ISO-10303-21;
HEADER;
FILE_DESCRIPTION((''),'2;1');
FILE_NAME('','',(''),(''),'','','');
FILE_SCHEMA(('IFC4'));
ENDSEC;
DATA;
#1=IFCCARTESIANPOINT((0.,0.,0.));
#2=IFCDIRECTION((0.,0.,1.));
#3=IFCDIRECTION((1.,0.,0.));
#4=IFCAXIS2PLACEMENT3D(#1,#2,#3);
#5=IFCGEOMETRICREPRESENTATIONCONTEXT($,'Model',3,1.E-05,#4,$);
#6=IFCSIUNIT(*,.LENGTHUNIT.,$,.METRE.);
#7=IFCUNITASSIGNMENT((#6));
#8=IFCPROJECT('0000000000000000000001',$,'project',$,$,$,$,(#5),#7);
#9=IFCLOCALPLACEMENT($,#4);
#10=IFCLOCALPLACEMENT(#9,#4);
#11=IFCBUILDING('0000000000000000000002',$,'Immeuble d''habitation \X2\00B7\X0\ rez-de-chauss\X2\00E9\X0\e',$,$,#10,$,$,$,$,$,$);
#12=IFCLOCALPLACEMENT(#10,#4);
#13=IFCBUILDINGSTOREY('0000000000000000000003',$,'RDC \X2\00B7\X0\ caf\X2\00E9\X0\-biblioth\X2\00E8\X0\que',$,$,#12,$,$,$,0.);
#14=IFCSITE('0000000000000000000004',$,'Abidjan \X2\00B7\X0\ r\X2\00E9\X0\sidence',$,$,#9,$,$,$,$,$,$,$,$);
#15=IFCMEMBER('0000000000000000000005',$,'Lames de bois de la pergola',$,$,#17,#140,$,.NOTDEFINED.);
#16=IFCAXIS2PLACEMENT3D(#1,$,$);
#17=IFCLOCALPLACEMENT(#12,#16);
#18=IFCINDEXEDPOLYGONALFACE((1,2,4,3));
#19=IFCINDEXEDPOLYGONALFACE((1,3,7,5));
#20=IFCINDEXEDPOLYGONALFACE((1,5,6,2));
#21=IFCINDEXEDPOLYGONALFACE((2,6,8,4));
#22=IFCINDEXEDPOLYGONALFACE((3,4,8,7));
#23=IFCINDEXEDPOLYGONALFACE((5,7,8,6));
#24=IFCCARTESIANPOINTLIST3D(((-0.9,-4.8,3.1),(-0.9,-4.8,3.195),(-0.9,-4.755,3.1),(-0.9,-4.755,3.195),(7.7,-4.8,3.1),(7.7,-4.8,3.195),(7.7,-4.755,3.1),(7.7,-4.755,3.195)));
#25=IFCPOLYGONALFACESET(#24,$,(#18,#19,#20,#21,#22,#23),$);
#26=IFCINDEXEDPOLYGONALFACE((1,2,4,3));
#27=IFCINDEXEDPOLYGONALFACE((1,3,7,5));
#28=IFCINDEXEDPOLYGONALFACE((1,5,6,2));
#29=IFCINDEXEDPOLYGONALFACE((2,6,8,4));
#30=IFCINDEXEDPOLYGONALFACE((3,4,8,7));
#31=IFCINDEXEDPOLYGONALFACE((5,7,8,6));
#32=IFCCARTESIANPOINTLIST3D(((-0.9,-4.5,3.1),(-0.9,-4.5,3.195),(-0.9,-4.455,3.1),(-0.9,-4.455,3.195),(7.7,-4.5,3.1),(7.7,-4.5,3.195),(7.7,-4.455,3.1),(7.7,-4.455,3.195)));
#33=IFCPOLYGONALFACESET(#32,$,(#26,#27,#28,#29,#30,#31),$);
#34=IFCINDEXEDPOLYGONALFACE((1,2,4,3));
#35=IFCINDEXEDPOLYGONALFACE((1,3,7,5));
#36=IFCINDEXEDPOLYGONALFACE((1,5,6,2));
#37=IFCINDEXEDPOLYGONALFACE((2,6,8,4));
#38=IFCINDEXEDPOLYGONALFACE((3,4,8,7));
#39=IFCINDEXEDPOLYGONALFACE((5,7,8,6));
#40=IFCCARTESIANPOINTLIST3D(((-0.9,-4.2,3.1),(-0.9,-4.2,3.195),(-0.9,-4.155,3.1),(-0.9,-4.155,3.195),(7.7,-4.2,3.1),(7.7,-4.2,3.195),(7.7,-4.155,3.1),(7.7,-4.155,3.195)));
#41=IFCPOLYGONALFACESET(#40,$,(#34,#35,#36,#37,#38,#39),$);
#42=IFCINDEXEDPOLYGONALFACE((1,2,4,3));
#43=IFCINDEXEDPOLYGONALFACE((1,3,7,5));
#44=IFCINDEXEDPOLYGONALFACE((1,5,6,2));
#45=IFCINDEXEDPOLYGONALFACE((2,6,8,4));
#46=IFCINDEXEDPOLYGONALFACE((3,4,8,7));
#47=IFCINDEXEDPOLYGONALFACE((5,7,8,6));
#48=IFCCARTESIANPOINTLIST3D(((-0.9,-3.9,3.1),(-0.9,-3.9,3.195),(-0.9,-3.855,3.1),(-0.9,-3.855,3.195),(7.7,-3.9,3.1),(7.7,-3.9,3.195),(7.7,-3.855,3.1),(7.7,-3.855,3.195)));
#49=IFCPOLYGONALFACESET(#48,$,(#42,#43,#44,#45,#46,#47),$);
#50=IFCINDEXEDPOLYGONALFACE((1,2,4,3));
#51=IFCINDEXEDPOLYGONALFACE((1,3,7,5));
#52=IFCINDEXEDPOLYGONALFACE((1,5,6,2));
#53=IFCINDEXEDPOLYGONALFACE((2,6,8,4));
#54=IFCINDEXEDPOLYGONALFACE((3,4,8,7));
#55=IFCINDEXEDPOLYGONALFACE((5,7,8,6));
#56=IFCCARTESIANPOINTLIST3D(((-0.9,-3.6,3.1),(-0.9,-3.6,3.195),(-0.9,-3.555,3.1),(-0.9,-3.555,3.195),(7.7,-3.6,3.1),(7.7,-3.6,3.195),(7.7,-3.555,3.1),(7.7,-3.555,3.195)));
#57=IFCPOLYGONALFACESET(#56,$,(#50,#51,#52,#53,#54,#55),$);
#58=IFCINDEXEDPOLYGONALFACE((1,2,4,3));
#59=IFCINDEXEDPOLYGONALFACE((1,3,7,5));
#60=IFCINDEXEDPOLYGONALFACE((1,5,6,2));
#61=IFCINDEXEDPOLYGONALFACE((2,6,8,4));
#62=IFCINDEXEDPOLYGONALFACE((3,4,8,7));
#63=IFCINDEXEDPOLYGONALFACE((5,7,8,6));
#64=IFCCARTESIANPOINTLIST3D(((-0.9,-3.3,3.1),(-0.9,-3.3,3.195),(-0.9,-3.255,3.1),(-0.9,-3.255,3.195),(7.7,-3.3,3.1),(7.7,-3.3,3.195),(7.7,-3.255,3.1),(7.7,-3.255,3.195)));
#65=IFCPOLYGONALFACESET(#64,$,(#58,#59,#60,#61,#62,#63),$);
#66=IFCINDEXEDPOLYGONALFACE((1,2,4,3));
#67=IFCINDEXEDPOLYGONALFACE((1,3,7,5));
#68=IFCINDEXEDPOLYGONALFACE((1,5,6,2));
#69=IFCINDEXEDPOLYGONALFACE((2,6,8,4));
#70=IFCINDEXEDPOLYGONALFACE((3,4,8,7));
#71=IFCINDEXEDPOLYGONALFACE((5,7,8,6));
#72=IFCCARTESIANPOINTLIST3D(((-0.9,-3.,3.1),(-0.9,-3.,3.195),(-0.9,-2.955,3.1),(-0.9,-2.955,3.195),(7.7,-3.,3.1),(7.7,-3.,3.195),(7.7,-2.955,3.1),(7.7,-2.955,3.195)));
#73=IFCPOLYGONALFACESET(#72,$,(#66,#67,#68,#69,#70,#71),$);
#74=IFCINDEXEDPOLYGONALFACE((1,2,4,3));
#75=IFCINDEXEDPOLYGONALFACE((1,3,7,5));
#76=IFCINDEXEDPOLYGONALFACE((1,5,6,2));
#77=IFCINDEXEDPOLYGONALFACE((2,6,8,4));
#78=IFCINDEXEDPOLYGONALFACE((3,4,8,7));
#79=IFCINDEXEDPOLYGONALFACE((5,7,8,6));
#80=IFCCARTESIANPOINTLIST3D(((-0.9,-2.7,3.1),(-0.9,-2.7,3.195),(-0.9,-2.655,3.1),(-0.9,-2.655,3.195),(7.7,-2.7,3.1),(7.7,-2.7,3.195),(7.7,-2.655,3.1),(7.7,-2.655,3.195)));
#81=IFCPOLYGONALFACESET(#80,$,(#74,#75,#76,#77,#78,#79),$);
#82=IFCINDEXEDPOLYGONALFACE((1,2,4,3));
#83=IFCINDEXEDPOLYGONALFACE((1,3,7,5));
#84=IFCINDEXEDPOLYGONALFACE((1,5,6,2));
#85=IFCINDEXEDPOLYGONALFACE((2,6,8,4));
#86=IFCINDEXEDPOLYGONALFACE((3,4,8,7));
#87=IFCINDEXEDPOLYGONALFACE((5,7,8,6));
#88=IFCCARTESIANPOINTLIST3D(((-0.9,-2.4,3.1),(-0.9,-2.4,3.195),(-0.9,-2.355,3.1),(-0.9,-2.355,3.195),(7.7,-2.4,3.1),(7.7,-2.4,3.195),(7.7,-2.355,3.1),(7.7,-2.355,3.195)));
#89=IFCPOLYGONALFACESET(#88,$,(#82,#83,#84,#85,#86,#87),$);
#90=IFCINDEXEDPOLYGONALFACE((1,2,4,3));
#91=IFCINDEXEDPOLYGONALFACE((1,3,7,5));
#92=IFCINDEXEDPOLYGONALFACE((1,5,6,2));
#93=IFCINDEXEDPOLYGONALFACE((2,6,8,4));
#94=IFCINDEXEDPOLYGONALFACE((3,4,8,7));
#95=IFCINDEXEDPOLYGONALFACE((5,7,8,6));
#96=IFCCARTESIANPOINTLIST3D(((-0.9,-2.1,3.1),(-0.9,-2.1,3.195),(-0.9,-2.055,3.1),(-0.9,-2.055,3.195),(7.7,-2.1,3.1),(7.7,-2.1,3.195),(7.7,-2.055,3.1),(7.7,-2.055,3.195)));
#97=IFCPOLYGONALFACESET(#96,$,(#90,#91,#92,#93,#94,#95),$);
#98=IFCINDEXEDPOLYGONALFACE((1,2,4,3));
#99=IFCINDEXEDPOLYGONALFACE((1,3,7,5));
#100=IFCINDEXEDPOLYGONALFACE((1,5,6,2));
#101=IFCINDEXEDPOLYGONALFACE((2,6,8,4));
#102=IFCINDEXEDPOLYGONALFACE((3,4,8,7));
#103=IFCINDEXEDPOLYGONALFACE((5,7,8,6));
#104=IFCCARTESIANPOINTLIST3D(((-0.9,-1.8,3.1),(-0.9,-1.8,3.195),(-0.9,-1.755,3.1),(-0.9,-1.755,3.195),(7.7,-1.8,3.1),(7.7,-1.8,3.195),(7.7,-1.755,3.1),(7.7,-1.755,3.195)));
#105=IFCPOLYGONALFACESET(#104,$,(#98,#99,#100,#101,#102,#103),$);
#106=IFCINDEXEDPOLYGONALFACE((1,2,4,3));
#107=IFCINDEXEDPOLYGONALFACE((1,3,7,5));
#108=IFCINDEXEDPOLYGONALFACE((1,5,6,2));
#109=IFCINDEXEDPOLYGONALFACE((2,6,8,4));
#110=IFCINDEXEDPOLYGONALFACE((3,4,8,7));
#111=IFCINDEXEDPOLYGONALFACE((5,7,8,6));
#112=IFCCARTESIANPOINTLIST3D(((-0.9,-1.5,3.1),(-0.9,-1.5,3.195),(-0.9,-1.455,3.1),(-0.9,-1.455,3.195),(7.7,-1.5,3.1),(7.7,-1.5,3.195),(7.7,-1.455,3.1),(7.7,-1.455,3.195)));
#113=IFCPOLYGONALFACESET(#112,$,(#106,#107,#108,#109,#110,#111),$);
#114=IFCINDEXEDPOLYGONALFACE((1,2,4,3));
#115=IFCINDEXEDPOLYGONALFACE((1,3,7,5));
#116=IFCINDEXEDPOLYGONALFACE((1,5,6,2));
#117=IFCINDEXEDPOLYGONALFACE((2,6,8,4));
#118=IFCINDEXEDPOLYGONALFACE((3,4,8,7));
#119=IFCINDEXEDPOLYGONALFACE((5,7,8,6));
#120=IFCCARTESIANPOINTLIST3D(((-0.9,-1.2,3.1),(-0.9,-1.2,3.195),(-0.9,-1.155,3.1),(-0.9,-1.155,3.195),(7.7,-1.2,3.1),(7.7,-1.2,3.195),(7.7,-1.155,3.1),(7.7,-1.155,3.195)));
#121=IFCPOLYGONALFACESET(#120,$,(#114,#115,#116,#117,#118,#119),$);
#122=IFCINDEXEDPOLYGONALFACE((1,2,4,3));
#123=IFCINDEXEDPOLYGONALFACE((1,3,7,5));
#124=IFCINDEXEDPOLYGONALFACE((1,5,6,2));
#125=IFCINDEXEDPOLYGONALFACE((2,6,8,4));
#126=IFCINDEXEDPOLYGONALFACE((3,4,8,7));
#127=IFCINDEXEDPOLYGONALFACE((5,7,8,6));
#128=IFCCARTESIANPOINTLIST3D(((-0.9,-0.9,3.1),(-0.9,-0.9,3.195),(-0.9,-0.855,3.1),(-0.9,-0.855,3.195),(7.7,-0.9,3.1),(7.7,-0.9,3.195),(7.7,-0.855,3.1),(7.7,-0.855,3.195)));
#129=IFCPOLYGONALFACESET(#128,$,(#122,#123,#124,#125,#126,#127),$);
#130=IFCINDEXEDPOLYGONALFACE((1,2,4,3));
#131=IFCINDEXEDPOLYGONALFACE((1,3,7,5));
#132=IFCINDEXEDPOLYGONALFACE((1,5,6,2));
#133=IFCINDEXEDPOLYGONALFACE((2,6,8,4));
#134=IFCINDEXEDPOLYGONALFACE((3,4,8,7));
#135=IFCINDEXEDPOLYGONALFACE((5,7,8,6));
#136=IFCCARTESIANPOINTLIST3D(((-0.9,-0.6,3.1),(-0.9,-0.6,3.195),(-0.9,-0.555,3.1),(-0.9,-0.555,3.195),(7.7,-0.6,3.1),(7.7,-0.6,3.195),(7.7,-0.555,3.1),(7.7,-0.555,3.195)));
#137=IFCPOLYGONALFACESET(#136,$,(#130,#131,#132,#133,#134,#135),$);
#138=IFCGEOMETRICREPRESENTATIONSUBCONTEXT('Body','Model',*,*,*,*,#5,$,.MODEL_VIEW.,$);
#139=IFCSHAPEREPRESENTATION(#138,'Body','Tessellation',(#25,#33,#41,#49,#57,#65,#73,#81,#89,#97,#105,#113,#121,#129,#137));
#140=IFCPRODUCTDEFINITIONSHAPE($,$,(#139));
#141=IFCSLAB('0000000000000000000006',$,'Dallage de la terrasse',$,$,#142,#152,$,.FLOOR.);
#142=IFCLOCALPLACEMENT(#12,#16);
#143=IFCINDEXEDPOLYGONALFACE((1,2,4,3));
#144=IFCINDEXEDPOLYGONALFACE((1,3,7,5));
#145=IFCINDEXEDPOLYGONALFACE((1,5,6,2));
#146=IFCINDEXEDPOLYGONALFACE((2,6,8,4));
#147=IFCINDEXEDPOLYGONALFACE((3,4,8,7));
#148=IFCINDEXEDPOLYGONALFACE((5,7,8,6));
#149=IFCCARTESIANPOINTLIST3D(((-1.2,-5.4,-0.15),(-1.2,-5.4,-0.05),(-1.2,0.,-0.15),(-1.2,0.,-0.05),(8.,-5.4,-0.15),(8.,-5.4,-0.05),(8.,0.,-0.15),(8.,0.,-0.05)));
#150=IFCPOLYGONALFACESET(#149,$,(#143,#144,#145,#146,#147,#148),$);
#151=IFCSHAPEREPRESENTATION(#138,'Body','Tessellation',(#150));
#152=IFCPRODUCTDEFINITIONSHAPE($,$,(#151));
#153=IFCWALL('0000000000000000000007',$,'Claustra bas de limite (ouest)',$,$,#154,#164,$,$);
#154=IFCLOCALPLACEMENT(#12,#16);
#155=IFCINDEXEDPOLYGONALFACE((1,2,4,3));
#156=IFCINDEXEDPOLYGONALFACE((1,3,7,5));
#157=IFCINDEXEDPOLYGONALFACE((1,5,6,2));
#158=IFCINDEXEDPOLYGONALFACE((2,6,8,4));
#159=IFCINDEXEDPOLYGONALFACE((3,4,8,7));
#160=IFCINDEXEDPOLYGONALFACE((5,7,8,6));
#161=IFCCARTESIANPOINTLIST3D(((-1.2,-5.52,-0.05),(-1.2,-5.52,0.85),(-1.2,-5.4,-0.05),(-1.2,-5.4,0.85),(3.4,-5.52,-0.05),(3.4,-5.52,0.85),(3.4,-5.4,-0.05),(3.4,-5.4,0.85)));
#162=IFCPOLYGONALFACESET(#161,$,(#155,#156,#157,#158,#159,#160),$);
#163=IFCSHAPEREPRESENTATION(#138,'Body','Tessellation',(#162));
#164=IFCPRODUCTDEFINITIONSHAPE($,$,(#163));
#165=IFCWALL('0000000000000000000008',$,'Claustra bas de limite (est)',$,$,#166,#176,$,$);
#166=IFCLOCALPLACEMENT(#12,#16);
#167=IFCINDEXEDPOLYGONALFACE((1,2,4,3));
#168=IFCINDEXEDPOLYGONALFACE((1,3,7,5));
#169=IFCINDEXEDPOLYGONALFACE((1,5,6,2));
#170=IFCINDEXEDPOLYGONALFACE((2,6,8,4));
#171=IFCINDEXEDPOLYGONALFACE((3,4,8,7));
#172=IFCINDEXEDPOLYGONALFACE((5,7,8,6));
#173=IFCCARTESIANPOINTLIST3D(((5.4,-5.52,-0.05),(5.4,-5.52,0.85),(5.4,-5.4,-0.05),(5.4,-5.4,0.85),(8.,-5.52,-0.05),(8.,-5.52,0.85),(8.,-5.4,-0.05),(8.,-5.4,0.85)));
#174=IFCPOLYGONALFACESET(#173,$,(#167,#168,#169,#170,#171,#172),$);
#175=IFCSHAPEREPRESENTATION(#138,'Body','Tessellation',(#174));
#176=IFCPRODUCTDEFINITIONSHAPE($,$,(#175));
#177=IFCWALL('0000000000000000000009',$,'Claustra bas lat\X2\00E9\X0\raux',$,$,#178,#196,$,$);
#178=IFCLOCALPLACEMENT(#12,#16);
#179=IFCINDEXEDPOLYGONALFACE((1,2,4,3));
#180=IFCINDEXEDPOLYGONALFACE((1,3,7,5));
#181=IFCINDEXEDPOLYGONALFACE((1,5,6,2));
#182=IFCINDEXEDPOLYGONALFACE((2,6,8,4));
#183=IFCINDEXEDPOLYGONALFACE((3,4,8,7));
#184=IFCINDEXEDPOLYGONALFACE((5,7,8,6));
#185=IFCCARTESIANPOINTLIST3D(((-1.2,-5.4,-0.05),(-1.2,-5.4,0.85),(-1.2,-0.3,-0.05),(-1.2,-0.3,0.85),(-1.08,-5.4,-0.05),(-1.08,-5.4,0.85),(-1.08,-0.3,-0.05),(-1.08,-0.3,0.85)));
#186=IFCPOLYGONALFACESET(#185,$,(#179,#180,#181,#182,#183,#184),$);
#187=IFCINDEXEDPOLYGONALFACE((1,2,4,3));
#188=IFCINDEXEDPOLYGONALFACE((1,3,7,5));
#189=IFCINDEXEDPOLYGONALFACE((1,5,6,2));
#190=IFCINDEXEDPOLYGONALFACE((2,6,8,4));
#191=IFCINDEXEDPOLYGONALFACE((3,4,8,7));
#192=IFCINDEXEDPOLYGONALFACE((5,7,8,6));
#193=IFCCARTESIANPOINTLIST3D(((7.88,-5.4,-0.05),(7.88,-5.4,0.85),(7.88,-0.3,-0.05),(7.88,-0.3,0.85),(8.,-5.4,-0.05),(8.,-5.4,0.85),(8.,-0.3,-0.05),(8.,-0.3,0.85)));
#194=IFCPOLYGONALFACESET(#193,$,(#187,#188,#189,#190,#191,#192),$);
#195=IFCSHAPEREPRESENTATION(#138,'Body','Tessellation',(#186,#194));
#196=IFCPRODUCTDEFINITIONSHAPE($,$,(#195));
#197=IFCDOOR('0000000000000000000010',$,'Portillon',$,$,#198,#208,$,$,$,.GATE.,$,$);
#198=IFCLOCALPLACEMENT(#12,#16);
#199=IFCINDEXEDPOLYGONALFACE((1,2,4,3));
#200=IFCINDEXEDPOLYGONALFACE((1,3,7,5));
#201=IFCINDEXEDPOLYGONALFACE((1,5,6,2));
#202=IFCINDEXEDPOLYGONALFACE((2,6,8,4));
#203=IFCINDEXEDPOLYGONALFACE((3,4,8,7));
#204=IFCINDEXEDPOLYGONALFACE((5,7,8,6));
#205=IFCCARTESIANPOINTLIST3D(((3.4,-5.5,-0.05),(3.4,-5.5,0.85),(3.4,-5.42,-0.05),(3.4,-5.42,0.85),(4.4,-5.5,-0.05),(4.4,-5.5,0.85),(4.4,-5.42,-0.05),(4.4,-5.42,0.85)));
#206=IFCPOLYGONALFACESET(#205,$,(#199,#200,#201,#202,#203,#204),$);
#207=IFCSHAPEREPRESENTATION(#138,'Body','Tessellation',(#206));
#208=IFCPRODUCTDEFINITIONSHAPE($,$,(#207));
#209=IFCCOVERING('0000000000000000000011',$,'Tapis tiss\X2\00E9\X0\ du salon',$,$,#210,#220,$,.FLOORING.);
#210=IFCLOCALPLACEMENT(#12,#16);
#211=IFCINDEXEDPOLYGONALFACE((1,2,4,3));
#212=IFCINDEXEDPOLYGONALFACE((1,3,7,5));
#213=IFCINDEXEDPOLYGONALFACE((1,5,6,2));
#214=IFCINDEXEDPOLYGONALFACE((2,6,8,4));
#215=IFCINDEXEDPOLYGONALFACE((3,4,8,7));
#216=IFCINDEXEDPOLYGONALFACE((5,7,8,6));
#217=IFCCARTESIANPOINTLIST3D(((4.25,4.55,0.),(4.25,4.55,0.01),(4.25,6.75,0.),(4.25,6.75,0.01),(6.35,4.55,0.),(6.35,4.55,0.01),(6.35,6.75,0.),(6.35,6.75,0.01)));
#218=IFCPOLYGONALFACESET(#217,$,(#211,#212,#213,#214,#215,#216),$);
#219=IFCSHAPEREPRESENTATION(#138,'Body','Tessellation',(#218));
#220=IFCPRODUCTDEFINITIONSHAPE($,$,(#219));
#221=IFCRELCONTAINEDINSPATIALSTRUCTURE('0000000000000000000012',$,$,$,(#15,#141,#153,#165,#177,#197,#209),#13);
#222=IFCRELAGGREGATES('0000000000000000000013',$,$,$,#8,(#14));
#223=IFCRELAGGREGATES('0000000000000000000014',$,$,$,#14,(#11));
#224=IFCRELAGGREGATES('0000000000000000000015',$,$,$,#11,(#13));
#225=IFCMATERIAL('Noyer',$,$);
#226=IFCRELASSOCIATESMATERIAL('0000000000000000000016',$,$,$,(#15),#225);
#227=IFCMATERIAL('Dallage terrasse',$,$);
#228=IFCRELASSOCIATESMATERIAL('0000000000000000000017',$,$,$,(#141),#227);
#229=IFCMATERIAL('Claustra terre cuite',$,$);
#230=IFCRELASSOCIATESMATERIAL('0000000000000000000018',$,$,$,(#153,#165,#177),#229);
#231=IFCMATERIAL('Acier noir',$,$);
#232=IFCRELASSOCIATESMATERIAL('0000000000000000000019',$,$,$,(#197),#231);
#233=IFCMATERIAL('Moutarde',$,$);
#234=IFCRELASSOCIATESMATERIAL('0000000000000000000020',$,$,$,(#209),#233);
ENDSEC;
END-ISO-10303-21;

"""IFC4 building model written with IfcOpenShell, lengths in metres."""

from ifc_helpers import new_model, si_unit, frame, frame_2d, origin, origin_with_axes, place, context, subcontext, project, spatial, rectangle, extrude, material, element, save


model = new_model("IFC4")

# Units and contexts
model_context = context("Model", 3, precision=1e-05, world=origin_with_axes())
body_context = subcontext(model_context, "Body", "Model", "MODEL_VIEW")
ifc_project = project(units=[si_unit("LENGTHUNIT", "METRE")], contexts=[model_context])

# Site, building, storey
site_placement = place(None, origin_with_axes())
site = spatial("IfcSite", under=ifc_project, at=site_placement, Name="Abidjan · résidence")
building_placement = place(site_placement, origin_with_axes())
building = spatial("IfcBuilding", under=site, at=building_placement, Name="Immeuble d'habitation · rez-de-chaussée")
storey_placement = place(building_placement, origin_with_axes())
storey = spatial("IfcBuildingStorey", under=building, at=storey_placement, Name="RDC · café-bibliothèque", Elevation=0.0)

# Shared definitions
ifc_material_1 = material(Name="Acier noir")

# Member
ifc_material_2 = material(Name="Noyer")
member_placement = place(storey_placement, origin_with_axes())
element("IfcMember", 1, at=member_placement, inside=storey, material=ifc_material_2, Name="Lames de bois de la pergola", PredefinedType="NOTDEFINED", context=body_context, shape_type="SweptSolid", body=[
    extrude(rectangle(XDim=8.6, YDim=0.045, at=frame_2d((3.4, -4.7775))), frame((0.0, 0.0, 3.1)), (0.0, 0.0, 1.0), 0.095),
    extrude(rectangle(XDim=8.6, YDim=0.045, at=frame_2d((3.4, -4.4775))), frame((0.0, 0.0, 3.1)), (0.0, 0.0, 1.0), 0.095),
    extrude(rectangle(XDim=8.6, YDim=0.045, at=frame_2d((3.4, -4.1775))), frame((0.0, 0.0, 3.1)), (0.0, 0.0, 1.0), 0.095),
    extrude(rectangle(XDim=8.6, YDim=0.045, at=frame_2d((3.4, -3.8775))), frame((0.0, 0.0, 3.1)), (0.0, 0.0, 1.0), 0.095),
    extrude(rectangle(XDim=8.6, YDim=0.045, at=frame_2d((3.4, -3.5775))), frame((0.0, 0.0, 3.1)), (0.0, 0.0, 1.0), 0.095),
    extrude(rectangle(XDim=8.6, YDim=0.045, at=frame_2d((3.4, -3.2775))), frame((0.0, 0.0, 3.1)), (0.0, 0.0, 1.0), 0.095),
    extrude(rectangle(XDim=8.6, YDim=0.045, at=frame_2d((3.4, -2.9775))), frame((0.0, 0.0, 3.1)), (0.0, 0.0, 1.0), 0.095),
    extrude(rectangle(XDim=8.6, YDim=0.045, at=frame_2d((3.4, -2.6775))), frame((0.0, 0.0, 3.1)), (0.0, 0.0, 1.0), 0.095),
    extrude(rectangle(XDim=8.6, YDim=0.045, at=frame_2d((3.4, -2.3775))), frame((0.0, 0.0, 3.1)), (0.0, 0.0, 1.0), 0.095),
    extrude(rectangle(XDim=8.6, YDim=0.045, at=frame_2d((3.4, -2.0775))), frame((0.0, 0.0, 3.1)), (0.0, 0.0, 1.0), 0.095),
    extrude(rectangle(XDim=8.6, YDim=0.045, at=frame_2d((3.4, -1.7775))), frame((0.0, 0.0, 3.1)), (0.0, 0.0, 1.0), 0.095),
    extrude(rectangle(XDim=8.6, YDim=0.045, at=frame_2d((3.4, -1.4775))), frame((0.0, 0.0, 3.1)), (0.0, 0.0, 1.0), 0.095),
    extrude(rectangle(XDim=8.6, YDim=0.045, at=frame_2d((3.4, -1.1775))), frame((0.0, 0.0, 3.1)), (0.0, 0.0, 1.0), 0.095),
    extrude(rectangle(XDim=8.6, YDim=0.045, at=frame_2d((3.4, -0.8775))), frame((0.0, 0.0, 3.1)), (0.0, 0.0, 1.0), 0.095),
    extrude(rectangle(XDim=8.6, YDim=0.045, at=frame_2d((3.4, -0.5775))), frame((0.0, 0.0, 3.1)), (0.0, 0.0, 1.0), 0.095),
])

# Slab
ifc_material_3 = material(Name="Dallage terrasse")
slab_placement = place(storey_placement, origin_with_axes())
element("IfcSlab", 2, at=slab_placement, inside=storey, material=ifc_material_3, Name="Dallage de la terrasse", PredefinedType="FLOOR", context=body_context, shape_type="SweptSolid", body=[
    extrude(rectangle(XDim=9.2, YDim=5.4, at=frame_2d((3.4, -2.7))), frame((0.0, 0.0, -0.15)), (0.0, 0.0, 1.0), 0.1),
])

# Walls
ifc_material_4 = material(Name="Claustra terre cuite")
wall_1_placement = place(storey_placement, origin_with_axes())
element("IfcWall", 3, at=wall_1_placement, inside=storey, material=ifc_material_4, Name="Claustra bas de limite (ouest)", context=body_context, shape_type="SweptSolid", body=[
    extrude(rectangle(XDim=4.6, YDim=0.12, at=frame_2d((1.1, -5.46))), frame((0.0, 0.0, -0.05)), (0.0, 0.0, 1.0), 0.9),
])
wall_2_placement = place(storey_placement, origin_with_axes())
element("IfcWall", 4, at=wall_2_placement, inside=storey, material=ifc_material_4, Name="Claustra bas de limite (est)", context=body_context, shape_type="SweptSolid", body=[
    extrude(rectangle(XDim=2.6, YDim=0.12, at=frame_2d((6.7, -5.46))), frame((0.0, 0.0, -0.05)), (0.0, 0.0, 1.0), 0.9),
])
wall_3_placement = place(storey_placement, origin_with_axes())
element("IfcWall", 5, at=wall_3_placement, inside=storey, material=ifc_material_4, Name="Claustra bas latéraux", context=body_context, shape_type="SweptSolid", body=[
    extrude(rectangle(XDim=0.12, YDim=5.1, at=frame_2d((-1.14, -2.85))), frame((0.0, 0.0, -0.05)), (0.0, 0.0, 1.0), 0.9),
    extrude(rectangle(XDim=0.12, YDim=5.1, at=frame_2d((7.94, -2.85))), frame((0.0, 0.0, -0.05)), (0.0, 0.0, 1.0), 0.9),
])

# Door
door_placement = place(storey_placement, origin_with_axes())
element("IfcDoor", 6, at=door_placement, inside=storey, material=ifc_material_1, Name="Portillon", PredefinedType="GATE", context=body_context, shape_type="SweptSolid", body=[
    extrude(rectangle(XDim=1.0, YDim=0.08, at=frame_2d((3.9, -5.46))), frame((0.0, 0.0, -0.05)), (0.0, 0.0, 1.0), 0.9),
])

# Covering
ifc_material_5 = material(Name="Moutarde")
covering_placement = place(storey_placement, origin_with_axes())
element("IfcCovering", 7, at=covering_placement, inside=storey, material=ifc_material_5, Name="Tapis tissé du salon", PredefinedType="FLOORING", context=body_context, shape_type="SweptSolid", body=[
    extrude(rectangle(XDim=2.1, YDim=2.2, at=frame_2d((5.3, 5.65))), origin(), (0.0, 0.0, 1.0), 0.01),
])

save(model, "model.ifc")
